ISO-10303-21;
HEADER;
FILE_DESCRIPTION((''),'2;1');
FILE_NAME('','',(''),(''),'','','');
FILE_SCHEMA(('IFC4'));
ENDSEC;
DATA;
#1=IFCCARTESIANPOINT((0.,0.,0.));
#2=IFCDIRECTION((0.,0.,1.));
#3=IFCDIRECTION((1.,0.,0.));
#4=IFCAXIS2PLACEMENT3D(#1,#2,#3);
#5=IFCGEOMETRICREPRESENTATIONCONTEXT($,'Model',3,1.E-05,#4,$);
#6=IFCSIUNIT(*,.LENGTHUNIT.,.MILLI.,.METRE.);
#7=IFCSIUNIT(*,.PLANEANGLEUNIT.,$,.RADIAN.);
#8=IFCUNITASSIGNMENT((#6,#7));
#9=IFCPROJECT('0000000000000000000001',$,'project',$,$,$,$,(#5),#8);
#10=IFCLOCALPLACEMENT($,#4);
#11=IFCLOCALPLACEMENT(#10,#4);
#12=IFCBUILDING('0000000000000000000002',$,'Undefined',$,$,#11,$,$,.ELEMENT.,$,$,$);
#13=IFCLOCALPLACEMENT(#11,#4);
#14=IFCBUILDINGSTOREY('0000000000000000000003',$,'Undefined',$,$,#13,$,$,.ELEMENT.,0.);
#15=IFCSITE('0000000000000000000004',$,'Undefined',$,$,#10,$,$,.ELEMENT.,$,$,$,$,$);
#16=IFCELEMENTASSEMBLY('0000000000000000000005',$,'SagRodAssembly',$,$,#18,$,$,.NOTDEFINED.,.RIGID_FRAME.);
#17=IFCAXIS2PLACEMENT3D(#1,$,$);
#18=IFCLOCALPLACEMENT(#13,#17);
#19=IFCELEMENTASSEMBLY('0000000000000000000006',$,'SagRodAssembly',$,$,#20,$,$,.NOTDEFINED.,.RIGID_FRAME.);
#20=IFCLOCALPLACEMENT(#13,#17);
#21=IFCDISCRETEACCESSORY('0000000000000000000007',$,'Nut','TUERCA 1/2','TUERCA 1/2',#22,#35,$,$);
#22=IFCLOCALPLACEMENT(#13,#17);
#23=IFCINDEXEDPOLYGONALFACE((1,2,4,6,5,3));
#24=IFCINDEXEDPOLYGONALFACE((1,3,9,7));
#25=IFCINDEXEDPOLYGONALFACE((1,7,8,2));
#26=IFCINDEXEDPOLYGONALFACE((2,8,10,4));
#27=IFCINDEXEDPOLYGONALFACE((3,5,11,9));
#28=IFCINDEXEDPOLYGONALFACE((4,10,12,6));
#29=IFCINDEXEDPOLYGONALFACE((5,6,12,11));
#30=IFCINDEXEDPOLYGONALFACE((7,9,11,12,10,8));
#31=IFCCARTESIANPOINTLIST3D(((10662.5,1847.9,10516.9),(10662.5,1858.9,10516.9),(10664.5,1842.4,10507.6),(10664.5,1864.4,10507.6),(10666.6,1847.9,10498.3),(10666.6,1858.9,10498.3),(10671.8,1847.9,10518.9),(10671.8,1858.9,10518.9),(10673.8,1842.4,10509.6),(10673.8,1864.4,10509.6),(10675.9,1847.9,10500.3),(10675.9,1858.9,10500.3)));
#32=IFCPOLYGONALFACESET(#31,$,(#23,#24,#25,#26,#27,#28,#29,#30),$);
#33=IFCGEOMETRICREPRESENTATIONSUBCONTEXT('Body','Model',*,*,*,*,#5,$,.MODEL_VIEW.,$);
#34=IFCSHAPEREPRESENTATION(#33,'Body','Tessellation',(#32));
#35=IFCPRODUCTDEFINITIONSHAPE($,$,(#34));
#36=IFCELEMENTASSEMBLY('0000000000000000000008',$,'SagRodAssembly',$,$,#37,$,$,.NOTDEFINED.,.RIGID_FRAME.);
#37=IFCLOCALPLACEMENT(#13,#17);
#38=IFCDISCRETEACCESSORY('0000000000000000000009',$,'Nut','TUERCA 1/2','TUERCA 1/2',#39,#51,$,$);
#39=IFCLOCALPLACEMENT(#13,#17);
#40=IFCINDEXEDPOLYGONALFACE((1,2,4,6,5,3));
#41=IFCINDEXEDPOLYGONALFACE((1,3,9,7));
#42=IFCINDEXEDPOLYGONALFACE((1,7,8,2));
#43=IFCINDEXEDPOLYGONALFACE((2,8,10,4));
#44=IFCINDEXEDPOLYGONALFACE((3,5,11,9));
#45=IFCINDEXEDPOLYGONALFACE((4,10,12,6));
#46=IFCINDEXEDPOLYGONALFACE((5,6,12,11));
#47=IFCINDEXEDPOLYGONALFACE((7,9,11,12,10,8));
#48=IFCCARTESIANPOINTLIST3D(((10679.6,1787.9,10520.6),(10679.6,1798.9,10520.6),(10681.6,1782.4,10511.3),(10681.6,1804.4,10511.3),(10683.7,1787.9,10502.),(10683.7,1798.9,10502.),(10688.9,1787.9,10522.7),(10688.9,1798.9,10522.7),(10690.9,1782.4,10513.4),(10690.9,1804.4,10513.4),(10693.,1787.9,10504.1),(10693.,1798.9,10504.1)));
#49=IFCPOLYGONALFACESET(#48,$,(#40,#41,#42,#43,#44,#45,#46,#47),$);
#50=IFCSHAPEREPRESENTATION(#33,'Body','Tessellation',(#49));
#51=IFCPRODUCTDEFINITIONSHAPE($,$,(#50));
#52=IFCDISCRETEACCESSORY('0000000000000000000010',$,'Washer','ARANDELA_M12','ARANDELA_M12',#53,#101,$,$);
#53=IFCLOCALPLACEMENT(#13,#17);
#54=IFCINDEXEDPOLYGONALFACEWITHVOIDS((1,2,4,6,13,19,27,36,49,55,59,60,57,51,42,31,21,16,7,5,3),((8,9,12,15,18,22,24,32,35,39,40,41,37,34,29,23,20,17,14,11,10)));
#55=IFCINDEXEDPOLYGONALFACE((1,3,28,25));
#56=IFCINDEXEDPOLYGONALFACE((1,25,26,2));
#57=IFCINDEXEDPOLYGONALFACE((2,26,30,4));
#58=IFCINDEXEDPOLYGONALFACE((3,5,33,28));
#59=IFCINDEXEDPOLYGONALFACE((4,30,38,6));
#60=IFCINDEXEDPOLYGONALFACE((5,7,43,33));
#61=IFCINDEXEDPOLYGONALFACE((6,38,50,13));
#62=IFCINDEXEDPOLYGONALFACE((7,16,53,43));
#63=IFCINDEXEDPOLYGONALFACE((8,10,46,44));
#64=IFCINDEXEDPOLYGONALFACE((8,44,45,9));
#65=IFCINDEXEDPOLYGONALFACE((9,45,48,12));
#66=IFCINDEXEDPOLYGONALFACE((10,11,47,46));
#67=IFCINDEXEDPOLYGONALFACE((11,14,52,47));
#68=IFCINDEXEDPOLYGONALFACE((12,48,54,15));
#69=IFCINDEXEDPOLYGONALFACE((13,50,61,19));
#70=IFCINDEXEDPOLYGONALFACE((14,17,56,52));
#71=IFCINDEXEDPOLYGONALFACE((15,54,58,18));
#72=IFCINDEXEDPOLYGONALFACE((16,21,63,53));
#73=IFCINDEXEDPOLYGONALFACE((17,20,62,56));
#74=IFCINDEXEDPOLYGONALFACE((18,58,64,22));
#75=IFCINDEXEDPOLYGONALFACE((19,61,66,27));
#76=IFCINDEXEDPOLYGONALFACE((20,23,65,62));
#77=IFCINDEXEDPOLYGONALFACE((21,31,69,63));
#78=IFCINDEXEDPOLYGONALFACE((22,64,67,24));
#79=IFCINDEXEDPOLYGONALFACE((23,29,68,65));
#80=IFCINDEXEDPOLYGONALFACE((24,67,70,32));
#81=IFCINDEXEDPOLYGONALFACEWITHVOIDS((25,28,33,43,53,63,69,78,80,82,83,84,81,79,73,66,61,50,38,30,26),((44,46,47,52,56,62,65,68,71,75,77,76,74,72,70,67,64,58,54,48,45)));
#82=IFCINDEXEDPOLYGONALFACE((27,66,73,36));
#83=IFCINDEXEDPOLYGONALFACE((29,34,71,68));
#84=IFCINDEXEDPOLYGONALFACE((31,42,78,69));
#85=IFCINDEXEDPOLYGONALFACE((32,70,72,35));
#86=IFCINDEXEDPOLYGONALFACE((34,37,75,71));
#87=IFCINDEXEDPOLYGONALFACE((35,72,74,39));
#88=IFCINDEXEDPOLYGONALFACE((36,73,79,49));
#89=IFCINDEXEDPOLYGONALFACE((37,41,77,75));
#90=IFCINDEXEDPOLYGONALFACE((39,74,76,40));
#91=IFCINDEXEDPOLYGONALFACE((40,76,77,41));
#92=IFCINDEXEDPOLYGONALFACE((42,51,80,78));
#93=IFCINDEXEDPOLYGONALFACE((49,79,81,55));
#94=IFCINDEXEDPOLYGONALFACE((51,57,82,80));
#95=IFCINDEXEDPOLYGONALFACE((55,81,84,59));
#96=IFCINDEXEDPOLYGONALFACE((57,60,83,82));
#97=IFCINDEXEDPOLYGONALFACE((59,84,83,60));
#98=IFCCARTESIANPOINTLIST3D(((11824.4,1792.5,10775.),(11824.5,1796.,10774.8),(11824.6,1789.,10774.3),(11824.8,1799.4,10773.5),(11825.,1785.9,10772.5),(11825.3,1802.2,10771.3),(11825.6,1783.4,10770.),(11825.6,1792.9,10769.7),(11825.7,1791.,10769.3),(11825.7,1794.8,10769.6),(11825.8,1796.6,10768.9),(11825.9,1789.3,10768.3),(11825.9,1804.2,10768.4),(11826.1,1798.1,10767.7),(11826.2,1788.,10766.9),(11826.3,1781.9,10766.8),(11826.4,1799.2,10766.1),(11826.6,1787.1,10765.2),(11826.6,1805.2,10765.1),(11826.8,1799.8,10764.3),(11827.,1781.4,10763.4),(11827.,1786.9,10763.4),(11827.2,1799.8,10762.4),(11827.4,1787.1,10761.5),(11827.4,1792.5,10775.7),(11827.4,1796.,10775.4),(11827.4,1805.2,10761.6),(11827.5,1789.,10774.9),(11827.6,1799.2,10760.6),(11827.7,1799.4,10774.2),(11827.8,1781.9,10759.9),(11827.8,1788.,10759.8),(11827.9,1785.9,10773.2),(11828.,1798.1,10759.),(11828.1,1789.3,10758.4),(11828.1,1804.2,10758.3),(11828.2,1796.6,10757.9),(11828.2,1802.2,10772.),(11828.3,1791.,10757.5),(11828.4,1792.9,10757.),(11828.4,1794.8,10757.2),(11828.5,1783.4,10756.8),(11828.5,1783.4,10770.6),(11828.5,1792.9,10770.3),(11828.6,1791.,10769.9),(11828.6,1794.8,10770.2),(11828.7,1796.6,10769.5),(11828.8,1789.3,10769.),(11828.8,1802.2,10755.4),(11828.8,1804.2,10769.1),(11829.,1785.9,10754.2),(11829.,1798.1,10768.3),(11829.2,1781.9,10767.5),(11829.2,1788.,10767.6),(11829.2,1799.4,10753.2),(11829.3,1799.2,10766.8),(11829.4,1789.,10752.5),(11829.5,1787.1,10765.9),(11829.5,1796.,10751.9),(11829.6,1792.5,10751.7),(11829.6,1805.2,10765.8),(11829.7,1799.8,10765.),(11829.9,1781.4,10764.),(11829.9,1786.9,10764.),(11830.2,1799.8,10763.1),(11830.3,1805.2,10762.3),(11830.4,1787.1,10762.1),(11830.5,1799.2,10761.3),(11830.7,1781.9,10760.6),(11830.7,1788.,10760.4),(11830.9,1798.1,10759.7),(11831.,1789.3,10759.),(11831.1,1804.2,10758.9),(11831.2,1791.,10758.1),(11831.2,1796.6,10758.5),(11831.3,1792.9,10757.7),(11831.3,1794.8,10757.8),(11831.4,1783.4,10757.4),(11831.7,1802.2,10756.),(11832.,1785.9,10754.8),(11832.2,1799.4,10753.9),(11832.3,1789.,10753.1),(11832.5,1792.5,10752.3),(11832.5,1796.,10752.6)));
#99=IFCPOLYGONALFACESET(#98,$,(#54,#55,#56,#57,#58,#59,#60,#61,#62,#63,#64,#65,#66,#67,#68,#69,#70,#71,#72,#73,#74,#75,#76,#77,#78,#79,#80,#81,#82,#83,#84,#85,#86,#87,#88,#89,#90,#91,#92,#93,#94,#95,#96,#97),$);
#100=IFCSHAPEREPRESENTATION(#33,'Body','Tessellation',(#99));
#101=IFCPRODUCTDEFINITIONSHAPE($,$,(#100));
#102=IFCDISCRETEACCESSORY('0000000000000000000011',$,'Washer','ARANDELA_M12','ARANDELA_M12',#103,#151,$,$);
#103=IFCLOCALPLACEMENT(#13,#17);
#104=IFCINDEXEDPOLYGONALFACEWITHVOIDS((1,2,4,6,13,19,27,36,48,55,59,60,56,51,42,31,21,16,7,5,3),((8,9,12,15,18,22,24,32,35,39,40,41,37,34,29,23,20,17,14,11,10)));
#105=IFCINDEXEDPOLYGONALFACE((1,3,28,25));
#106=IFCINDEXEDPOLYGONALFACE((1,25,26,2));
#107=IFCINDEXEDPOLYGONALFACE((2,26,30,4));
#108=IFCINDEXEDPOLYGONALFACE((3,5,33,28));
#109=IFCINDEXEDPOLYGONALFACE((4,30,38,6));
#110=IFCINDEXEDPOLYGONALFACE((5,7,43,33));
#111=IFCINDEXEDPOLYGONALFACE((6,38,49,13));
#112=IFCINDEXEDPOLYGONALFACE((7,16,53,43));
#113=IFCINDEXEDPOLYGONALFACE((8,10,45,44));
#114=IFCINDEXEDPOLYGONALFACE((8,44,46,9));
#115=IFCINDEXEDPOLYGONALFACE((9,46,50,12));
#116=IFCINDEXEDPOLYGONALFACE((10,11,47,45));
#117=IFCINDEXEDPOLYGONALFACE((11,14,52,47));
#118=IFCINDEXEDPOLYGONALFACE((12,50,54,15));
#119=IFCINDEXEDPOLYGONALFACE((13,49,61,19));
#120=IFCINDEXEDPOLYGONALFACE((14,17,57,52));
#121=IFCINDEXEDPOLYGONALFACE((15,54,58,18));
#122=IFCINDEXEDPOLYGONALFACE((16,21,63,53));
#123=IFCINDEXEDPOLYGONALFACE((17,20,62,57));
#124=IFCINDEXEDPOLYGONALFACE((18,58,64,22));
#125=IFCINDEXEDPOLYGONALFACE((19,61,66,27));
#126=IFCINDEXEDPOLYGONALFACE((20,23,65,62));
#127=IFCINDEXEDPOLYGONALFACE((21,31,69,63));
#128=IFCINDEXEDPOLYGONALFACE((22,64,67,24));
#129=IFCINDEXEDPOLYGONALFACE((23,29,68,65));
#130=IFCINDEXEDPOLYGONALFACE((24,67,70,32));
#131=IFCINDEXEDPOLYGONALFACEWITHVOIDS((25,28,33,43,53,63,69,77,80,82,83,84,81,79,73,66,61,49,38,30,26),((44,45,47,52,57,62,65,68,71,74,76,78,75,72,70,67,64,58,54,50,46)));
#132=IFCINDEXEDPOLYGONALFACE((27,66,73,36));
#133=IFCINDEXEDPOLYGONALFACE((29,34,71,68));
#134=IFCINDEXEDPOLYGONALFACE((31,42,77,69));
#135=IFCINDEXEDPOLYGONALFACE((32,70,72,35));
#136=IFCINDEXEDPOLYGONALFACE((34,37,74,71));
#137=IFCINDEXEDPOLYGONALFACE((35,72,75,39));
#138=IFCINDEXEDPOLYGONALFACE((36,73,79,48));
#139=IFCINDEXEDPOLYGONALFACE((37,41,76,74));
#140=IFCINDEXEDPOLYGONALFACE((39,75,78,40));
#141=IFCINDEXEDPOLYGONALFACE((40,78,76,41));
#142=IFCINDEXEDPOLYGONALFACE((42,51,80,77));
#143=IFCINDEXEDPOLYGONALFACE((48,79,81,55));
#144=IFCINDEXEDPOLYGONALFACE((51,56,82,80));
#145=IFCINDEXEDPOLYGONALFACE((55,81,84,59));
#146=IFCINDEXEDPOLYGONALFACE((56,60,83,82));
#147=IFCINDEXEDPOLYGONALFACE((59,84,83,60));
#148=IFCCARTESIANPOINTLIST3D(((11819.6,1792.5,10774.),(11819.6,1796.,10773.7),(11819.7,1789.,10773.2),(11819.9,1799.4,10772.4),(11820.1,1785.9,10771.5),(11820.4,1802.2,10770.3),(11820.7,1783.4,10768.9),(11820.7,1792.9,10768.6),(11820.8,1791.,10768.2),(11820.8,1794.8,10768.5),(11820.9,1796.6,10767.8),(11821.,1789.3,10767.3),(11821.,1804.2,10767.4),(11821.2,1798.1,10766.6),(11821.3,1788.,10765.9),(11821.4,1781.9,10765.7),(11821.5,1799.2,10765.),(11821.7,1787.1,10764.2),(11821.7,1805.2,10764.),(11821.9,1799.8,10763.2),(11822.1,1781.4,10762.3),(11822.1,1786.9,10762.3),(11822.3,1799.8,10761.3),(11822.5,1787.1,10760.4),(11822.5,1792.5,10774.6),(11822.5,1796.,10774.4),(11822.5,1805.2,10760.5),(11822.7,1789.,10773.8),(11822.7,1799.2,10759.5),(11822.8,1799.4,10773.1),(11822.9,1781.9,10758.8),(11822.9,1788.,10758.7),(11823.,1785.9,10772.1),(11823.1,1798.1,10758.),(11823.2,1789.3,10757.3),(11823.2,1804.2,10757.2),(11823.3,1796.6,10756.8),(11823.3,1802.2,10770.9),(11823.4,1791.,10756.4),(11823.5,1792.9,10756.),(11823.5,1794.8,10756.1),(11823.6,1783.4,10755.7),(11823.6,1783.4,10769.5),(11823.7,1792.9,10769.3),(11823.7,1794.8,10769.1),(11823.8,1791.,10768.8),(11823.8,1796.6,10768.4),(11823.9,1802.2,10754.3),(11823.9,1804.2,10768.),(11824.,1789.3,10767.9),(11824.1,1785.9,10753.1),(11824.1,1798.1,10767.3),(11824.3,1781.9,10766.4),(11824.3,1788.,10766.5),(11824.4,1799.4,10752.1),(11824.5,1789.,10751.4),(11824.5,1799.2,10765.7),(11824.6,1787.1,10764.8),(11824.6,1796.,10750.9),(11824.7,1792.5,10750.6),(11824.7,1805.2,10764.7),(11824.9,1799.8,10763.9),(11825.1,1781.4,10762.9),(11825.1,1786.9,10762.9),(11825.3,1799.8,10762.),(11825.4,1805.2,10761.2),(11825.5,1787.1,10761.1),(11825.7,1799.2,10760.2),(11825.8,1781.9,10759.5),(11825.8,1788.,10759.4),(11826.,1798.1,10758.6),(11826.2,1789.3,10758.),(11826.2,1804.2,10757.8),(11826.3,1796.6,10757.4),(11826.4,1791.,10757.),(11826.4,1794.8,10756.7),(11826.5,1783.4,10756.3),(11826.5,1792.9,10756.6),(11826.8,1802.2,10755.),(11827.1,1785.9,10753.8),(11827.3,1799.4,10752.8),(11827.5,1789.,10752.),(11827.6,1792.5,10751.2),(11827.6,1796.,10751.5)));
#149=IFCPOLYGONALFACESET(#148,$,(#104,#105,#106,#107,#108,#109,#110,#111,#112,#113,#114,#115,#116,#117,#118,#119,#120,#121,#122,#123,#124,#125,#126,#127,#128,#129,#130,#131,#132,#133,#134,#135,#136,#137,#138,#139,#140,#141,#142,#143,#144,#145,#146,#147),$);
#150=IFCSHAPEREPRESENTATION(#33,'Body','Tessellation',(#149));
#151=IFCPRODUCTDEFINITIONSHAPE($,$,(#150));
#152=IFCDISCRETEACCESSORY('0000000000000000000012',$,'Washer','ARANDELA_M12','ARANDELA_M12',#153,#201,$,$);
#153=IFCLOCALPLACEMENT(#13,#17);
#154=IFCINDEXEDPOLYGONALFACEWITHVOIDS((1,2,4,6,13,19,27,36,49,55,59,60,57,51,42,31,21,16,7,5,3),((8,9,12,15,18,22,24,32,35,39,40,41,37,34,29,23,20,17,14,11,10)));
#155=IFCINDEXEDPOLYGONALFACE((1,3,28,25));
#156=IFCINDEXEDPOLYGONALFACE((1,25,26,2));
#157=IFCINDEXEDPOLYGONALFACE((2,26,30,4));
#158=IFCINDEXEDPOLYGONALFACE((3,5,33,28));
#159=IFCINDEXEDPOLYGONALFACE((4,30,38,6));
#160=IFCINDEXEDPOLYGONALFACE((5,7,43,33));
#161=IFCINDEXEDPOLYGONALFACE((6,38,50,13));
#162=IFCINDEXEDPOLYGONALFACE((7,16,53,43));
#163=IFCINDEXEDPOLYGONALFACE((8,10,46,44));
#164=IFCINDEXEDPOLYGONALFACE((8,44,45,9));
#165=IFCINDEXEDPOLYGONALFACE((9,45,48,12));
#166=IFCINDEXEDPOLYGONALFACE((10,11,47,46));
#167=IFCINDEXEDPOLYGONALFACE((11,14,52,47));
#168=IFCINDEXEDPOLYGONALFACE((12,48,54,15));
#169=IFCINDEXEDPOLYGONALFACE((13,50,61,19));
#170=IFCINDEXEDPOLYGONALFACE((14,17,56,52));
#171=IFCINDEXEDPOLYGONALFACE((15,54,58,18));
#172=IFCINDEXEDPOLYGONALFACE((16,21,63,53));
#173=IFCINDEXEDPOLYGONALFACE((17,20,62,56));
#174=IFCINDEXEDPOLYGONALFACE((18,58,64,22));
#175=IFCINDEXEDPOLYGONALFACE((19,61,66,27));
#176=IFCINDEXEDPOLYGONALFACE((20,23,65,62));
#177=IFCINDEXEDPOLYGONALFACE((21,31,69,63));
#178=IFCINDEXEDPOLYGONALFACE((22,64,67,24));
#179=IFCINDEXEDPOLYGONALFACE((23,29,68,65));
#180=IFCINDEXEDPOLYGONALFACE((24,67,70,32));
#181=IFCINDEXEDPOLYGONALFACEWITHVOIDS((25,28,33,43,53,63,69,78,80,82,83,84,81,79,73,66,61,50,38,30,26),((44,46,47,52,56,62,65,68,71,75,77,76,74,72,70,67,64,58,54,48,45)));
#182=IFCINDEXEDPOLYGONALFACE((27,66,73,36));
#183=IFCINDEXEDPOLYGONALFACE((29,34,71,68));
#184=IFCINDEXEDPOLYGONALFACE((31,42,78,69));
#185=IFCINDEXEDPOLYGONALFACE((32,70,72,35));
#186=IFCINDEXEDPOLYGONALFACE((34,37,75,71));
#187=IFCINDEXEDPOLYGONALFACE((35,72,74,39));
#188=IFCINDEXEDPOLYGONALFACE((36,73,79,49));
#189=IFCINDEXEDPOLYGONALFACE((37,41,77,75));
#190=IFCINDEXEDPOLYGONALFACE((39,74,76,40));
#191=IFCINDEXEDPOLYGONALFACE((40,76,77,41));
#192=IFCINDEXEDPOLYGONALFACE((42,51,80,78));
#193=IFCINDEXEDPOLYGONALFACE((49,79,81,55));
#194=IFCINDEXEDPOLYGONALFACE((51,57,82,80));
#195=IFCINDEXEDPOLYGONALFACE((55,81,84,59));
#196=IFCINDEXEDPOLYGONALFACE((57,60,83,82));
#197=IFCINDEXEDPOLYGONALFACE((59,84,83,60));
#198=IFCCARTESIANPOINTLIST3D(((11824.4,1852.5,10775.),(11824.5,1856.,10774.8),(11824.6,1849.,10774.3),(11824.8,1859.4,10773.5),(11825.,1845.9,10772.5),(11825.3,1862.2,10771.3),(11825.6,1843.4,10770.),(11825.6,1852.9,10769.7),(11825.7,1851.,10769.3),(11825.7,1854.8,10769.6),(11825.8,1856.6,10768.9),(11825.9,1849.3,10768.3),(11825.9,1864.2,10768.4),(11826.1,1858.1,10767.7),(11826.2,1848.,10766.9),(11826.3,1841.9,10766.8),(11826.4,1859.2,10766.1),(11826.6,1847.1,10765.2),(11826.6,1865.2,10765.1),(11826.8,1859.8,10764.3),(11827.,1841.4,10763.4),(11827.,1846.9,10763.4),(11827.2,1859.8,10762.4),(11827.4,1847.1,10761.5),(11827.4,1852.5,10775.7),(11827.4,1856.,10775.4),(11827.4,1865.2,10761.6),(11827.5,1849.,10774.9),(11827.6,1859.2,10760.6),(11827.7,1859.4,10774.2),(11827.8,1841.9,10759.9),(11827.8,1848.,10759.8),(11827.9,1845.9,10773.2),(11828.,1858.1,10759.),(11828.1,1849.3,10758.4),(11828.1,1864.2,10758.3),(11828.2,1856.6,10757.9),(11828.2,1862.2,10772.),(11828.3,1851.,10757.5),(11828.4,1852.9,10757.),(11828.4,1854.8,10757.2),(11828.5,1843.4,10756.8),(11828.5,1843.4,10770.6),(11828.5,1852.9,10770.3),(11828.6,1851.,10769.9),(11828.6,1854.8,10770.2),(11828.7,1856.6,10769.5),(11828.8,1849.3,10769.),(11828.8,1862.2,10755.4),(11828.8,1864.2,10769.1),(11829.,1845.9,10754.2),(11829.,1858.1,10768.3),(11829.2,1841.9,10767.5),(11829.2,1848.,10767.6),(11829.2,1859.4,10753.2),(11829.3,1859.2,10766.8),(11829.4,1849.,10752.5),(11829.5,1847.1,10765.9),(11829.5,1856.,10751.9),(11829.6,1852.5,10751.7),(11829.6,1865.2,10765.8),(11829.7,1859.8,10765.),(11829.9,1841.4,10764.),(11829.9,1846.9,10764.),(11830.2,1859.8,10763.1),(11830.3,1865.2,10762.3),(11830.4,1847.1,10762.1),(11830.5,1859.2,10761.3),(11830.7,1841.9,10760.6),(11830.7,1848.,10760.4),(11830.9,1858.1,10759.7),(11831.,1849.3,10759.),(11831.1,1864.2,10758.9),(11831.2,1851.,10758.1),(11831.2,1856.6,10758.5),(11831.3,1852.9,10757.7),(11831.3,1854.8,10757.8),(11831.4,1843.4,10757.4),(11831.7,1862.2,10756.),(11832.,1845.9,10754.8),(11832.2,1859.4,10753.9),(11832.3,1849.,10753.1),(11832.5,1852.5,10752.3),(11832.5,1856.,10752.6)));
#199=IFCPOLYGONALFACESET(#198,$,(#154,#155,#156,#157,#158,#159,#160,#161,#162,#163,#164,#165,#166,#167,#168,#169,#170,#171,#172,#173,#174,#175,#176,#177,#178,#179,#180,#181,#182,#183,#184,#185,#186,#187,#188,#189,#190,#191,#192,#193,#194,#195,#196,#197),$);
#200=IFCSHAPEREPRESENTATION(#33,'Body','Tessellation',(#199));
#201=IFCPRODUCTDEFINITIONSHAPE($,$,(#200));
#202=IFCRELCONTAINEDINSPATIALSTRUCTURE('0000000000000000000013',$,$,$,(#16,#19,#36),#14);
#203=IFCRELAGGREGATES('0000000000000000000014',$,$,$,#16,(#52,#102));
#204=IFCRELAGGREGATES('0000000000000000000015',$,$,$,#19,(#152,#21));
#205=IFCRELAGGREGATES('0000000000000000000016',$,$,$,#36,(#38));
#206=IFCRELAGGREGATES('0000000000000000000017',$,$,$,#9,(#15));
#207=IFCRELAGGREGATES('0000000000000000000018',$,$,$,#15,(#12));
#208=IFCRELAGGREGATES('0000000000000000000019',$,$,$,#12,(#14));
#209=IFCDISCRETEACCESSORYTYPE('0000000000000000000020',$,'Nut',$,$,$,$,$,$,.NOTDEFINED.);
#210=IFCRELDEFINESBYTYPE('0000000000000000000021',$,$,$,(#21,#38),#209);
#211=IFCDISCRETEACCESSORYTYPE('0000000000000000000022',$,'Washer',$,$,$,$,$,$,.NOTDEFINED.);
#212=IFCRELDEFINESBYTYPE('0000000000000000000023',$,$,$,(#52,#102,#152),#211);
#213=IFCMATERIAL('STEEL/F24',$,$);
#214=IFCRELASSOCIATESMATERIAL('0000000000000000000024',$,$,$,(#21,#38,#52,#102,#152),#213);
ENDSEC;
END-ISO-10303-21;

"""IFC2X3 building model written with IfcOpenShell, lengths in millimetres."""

from ifc_helpers import new_model, si_unit, frame, origin_with_axes, origin_2d_with_axis, place, context, subcontext, project, spatial, polyline, hollow_circle, outline, extrude, material, type_object, element, aggregate, save


model = new_model("IFC2X3")

# Units and contexts
model_context = context("Model", 3, precision=1e-05, world=origin_with_axes())
body_context = subcontext(model_context, "Body", "Model", "MODEL_VIEW")
ifc_project = project(units=[si_unit("LENGTHUNIT", "METRE", prefix="MILLI"), si_unit("PLANEANGLEUNIT", "RADIAN")], contexts=[model_context])

# Site, building, storey
site_placement = place(None, origin_with_axes())
site = spatial("IfcSite", under=ifc_project, at=site_placement, Name="Undefined", CompositionType="ELEMENT")
building_placement = place(site_placement, origin_with_axes())
building = spatial("IfcBuilding", under=site, at=building_placement, Name="Undefined", CompositionType="ELEMENT")
storey_placement = place(building_placement, origin_with_axes())
storey = spatial("IfcBuildingStorey", under=building, at=storey_placement, Name="Undefined", CompositionType="ELEMENT", Elevation=0.0)

# Element assembly
assembly_1_placement = place(storey_placement, origin_with_axes())
assembly_1 = element("IfcElementAssembly", 1, at=assembly_1_placement, inside=storey, Name="SagRodAssembly", AssemblyPlace="NOTDEFINED", PredefinedType="RIGID_FRAME")
ifc_material_1 = material(Name="STEEL/F24")

# Shared definitions
discrete_accessory_type_1 = type_object("IfcDiscreteAccessoryType", Name="Nut")

# Element assembly, discrete accessory
assembly_2_placement = place(storey_placement, origin_with_axes())
assembly_2 = element("IfcElementAssembly", 2, at=assembly_2_placement, inside=storey, Name="SagRodAssembly", AssemblyPlace="NOTDEFINED", PredefinedType="RIGID_FRAME")
discrete_accessory_1_placement = place(assembly_2_placement, frame((10664.5, 1853.4, 10507.6), z_axis=(-0.214887, 0.0, 0.976639), x_axis=(0.976639, 0.0, 0.214887)))
discrete_accessory_1 = element("IfcDiscreteAccessory", 3, at=discrete_accessory_1_placement, type_object=discrete_accessory_type_1, material=ifc_material_1, Name="Nut", Description="TUERCA 1/2", ObjectType="TUERCA 1/2", context=body_context, shape_type="SweptSolid", body=[
    extrude(outline(polyline([(-5.5, 9.5), (5.5, 9.5), (11.0, 0.0), (5.5, -9.5), (-5.5, -9.5), (-11.0, 0.0), (-5.5, 9.5)])), frame((9.5, 0.0, 0.0), z_axis=(-1.0, 0.0, 0.0), x_axis=(0.0, -1.0, 0.0)), (0.0, 0.0, 1.0), 9.5),
])

# Element assembly, discrete accessory
assembly_3_placement = place(storey_placement, origin_with_axes())
assembly_3 = element("IfcElementAssembly", 4, at=assembly_3_placement, inside=storey, Name="SagRodAssembly", AssemblyPlace="NOTDEFINED", PredefinedType="RIGID_FRAME")
discrete_accessory_2_placement = place(assembly_3_placement, frame((10681.6, 1793.4, 10511.3), z_axis=(-0.214887, 0.0, 0.976639), x_axis=(0.976639, 0.0, 0.214887)))
discrete_accessory_2 = element("IfcDiscreteAccessory", 5, at=discrete_accessory_2_placement, type_object=discrete_accessory_type_1, material=ifc_material_1, Name="Nut", Description="TUERCA 1/2", ObjectType="TUERCA 1/2", context=body_context, shape_type="SweptSolid", body=[
    extrude(outline(polyline([(-5.5, 9.5), (5.5, 9.5), (11.0, 0.0), (5.5, -9.5), (-5.5, -9.5), (-11.0, 0.0), (-5.5, 9.5)])), frame((9.5, 0.0, 0.0), z_axis=(-1.0, 0.0, 0.0), x_axis=(0.0, -1.0, 0.0)), (0.0, 0.0, 1.0), 9.5),
])

# Discrete accessories
discrete_accessory_type_2 = type_object("IfcDiscreteAccessoryType", Name="Washer")
discrete_accessory_3_placement = place(assembly_1_placement, frame((11827.0, 1793.4, 10763.4), z_axis=(-0.214887, 0.0, 0.976639), x_axis=(0.976639, 0.0, 0.214887)))
discrete_accessory_3 = element("IfcDiscreteAccessory", 6, at=discrete_accessory_3_placement, type_object=discrete_accessory_type_2, material=ifc_material_1, Name="Washer", Description="ARANDELA_M12", ObjectType="ARANDELA_M12", context=body_context, shape_type="SweptSolid", body=[
    extrude(hollow_circle(Radius=12.0, WallThickness=5.5, at=origin_2d_with_axis()), frame((3.0, 0.0, 0.0), z_axis=(-1.0, 0.0, 0.0), x_axis=(0.0, -1.0, 0.0)), (0.0, 0.0, 1.0), 3.0),
])
discrete_accessory_4_placement = place(assembly_1_placement, frame((11822.1, 1793.4, 10762.3), z_axis=(-0.214887, 0.0, 0.976639), x_axis=(0.976639, 0.0, 0.214887)))
discrete_accessory_4 = element("IfcDiscreteAccessory", 7, at=discrete_accessory_4_placement, type_object=discrete_accessory_type_2, material=ifc_material_1, Name="Washer", Description="ARANDELA_M12", ObjectType="ARANDELA_M12", context=body_context, shape_type="SweptSolid", body=[
    extrude(hollow_circle(Radius=12.0, WallThickness=5.5, at=origin_2d_with_axis()), frame((3.0, 0.0, 0.0), z_axis=(-1.0, 0.0, 0.0), x_axis=(0.0, -1.0, 0.0)), (0.0, 0.0, 1.0), 3.0),
])
aggregate(assembly_1, [discrete_accessory_3, discrete_accessory_4])
discrete_accessory_5_placement = place(assembly_2_placement, frame((11827.0, 1853.4, 10763.4), z_axis=(-0.214887, 0.0, 0.976639), x_axis=(0.976639, 0.0, 0.214887)))
discrete_accessory_5 = element("IfcDiscreteAccessory", 8, at=discrete_accessory_5_placement, type_object=discrete_accessory_type_2, material=ifc_material_1, Name="Washer", Description="ARANDELA_M12", ObjectType="ARANDELA_M12", context=body_context, shape_type="SweptSolid", body=[
    extrude(hollow_circle(Radius=12.0, WallThickness=5.5, at=origin_2d_with_axis()), frame((3.0, 0.0, 0.0), z_axis=(-1.0, 0.0, 0.0), x_axis=(0.0, -1.0, 0.0)), (0.0, 0.0, 1.0), 3.0),
])
aggregate(assembly_2, [discrete_accessory_5, discrete_accessory_1])
aggregate(assembly_3, [discrete_accessory_2])

save(model, "model.ifc")
